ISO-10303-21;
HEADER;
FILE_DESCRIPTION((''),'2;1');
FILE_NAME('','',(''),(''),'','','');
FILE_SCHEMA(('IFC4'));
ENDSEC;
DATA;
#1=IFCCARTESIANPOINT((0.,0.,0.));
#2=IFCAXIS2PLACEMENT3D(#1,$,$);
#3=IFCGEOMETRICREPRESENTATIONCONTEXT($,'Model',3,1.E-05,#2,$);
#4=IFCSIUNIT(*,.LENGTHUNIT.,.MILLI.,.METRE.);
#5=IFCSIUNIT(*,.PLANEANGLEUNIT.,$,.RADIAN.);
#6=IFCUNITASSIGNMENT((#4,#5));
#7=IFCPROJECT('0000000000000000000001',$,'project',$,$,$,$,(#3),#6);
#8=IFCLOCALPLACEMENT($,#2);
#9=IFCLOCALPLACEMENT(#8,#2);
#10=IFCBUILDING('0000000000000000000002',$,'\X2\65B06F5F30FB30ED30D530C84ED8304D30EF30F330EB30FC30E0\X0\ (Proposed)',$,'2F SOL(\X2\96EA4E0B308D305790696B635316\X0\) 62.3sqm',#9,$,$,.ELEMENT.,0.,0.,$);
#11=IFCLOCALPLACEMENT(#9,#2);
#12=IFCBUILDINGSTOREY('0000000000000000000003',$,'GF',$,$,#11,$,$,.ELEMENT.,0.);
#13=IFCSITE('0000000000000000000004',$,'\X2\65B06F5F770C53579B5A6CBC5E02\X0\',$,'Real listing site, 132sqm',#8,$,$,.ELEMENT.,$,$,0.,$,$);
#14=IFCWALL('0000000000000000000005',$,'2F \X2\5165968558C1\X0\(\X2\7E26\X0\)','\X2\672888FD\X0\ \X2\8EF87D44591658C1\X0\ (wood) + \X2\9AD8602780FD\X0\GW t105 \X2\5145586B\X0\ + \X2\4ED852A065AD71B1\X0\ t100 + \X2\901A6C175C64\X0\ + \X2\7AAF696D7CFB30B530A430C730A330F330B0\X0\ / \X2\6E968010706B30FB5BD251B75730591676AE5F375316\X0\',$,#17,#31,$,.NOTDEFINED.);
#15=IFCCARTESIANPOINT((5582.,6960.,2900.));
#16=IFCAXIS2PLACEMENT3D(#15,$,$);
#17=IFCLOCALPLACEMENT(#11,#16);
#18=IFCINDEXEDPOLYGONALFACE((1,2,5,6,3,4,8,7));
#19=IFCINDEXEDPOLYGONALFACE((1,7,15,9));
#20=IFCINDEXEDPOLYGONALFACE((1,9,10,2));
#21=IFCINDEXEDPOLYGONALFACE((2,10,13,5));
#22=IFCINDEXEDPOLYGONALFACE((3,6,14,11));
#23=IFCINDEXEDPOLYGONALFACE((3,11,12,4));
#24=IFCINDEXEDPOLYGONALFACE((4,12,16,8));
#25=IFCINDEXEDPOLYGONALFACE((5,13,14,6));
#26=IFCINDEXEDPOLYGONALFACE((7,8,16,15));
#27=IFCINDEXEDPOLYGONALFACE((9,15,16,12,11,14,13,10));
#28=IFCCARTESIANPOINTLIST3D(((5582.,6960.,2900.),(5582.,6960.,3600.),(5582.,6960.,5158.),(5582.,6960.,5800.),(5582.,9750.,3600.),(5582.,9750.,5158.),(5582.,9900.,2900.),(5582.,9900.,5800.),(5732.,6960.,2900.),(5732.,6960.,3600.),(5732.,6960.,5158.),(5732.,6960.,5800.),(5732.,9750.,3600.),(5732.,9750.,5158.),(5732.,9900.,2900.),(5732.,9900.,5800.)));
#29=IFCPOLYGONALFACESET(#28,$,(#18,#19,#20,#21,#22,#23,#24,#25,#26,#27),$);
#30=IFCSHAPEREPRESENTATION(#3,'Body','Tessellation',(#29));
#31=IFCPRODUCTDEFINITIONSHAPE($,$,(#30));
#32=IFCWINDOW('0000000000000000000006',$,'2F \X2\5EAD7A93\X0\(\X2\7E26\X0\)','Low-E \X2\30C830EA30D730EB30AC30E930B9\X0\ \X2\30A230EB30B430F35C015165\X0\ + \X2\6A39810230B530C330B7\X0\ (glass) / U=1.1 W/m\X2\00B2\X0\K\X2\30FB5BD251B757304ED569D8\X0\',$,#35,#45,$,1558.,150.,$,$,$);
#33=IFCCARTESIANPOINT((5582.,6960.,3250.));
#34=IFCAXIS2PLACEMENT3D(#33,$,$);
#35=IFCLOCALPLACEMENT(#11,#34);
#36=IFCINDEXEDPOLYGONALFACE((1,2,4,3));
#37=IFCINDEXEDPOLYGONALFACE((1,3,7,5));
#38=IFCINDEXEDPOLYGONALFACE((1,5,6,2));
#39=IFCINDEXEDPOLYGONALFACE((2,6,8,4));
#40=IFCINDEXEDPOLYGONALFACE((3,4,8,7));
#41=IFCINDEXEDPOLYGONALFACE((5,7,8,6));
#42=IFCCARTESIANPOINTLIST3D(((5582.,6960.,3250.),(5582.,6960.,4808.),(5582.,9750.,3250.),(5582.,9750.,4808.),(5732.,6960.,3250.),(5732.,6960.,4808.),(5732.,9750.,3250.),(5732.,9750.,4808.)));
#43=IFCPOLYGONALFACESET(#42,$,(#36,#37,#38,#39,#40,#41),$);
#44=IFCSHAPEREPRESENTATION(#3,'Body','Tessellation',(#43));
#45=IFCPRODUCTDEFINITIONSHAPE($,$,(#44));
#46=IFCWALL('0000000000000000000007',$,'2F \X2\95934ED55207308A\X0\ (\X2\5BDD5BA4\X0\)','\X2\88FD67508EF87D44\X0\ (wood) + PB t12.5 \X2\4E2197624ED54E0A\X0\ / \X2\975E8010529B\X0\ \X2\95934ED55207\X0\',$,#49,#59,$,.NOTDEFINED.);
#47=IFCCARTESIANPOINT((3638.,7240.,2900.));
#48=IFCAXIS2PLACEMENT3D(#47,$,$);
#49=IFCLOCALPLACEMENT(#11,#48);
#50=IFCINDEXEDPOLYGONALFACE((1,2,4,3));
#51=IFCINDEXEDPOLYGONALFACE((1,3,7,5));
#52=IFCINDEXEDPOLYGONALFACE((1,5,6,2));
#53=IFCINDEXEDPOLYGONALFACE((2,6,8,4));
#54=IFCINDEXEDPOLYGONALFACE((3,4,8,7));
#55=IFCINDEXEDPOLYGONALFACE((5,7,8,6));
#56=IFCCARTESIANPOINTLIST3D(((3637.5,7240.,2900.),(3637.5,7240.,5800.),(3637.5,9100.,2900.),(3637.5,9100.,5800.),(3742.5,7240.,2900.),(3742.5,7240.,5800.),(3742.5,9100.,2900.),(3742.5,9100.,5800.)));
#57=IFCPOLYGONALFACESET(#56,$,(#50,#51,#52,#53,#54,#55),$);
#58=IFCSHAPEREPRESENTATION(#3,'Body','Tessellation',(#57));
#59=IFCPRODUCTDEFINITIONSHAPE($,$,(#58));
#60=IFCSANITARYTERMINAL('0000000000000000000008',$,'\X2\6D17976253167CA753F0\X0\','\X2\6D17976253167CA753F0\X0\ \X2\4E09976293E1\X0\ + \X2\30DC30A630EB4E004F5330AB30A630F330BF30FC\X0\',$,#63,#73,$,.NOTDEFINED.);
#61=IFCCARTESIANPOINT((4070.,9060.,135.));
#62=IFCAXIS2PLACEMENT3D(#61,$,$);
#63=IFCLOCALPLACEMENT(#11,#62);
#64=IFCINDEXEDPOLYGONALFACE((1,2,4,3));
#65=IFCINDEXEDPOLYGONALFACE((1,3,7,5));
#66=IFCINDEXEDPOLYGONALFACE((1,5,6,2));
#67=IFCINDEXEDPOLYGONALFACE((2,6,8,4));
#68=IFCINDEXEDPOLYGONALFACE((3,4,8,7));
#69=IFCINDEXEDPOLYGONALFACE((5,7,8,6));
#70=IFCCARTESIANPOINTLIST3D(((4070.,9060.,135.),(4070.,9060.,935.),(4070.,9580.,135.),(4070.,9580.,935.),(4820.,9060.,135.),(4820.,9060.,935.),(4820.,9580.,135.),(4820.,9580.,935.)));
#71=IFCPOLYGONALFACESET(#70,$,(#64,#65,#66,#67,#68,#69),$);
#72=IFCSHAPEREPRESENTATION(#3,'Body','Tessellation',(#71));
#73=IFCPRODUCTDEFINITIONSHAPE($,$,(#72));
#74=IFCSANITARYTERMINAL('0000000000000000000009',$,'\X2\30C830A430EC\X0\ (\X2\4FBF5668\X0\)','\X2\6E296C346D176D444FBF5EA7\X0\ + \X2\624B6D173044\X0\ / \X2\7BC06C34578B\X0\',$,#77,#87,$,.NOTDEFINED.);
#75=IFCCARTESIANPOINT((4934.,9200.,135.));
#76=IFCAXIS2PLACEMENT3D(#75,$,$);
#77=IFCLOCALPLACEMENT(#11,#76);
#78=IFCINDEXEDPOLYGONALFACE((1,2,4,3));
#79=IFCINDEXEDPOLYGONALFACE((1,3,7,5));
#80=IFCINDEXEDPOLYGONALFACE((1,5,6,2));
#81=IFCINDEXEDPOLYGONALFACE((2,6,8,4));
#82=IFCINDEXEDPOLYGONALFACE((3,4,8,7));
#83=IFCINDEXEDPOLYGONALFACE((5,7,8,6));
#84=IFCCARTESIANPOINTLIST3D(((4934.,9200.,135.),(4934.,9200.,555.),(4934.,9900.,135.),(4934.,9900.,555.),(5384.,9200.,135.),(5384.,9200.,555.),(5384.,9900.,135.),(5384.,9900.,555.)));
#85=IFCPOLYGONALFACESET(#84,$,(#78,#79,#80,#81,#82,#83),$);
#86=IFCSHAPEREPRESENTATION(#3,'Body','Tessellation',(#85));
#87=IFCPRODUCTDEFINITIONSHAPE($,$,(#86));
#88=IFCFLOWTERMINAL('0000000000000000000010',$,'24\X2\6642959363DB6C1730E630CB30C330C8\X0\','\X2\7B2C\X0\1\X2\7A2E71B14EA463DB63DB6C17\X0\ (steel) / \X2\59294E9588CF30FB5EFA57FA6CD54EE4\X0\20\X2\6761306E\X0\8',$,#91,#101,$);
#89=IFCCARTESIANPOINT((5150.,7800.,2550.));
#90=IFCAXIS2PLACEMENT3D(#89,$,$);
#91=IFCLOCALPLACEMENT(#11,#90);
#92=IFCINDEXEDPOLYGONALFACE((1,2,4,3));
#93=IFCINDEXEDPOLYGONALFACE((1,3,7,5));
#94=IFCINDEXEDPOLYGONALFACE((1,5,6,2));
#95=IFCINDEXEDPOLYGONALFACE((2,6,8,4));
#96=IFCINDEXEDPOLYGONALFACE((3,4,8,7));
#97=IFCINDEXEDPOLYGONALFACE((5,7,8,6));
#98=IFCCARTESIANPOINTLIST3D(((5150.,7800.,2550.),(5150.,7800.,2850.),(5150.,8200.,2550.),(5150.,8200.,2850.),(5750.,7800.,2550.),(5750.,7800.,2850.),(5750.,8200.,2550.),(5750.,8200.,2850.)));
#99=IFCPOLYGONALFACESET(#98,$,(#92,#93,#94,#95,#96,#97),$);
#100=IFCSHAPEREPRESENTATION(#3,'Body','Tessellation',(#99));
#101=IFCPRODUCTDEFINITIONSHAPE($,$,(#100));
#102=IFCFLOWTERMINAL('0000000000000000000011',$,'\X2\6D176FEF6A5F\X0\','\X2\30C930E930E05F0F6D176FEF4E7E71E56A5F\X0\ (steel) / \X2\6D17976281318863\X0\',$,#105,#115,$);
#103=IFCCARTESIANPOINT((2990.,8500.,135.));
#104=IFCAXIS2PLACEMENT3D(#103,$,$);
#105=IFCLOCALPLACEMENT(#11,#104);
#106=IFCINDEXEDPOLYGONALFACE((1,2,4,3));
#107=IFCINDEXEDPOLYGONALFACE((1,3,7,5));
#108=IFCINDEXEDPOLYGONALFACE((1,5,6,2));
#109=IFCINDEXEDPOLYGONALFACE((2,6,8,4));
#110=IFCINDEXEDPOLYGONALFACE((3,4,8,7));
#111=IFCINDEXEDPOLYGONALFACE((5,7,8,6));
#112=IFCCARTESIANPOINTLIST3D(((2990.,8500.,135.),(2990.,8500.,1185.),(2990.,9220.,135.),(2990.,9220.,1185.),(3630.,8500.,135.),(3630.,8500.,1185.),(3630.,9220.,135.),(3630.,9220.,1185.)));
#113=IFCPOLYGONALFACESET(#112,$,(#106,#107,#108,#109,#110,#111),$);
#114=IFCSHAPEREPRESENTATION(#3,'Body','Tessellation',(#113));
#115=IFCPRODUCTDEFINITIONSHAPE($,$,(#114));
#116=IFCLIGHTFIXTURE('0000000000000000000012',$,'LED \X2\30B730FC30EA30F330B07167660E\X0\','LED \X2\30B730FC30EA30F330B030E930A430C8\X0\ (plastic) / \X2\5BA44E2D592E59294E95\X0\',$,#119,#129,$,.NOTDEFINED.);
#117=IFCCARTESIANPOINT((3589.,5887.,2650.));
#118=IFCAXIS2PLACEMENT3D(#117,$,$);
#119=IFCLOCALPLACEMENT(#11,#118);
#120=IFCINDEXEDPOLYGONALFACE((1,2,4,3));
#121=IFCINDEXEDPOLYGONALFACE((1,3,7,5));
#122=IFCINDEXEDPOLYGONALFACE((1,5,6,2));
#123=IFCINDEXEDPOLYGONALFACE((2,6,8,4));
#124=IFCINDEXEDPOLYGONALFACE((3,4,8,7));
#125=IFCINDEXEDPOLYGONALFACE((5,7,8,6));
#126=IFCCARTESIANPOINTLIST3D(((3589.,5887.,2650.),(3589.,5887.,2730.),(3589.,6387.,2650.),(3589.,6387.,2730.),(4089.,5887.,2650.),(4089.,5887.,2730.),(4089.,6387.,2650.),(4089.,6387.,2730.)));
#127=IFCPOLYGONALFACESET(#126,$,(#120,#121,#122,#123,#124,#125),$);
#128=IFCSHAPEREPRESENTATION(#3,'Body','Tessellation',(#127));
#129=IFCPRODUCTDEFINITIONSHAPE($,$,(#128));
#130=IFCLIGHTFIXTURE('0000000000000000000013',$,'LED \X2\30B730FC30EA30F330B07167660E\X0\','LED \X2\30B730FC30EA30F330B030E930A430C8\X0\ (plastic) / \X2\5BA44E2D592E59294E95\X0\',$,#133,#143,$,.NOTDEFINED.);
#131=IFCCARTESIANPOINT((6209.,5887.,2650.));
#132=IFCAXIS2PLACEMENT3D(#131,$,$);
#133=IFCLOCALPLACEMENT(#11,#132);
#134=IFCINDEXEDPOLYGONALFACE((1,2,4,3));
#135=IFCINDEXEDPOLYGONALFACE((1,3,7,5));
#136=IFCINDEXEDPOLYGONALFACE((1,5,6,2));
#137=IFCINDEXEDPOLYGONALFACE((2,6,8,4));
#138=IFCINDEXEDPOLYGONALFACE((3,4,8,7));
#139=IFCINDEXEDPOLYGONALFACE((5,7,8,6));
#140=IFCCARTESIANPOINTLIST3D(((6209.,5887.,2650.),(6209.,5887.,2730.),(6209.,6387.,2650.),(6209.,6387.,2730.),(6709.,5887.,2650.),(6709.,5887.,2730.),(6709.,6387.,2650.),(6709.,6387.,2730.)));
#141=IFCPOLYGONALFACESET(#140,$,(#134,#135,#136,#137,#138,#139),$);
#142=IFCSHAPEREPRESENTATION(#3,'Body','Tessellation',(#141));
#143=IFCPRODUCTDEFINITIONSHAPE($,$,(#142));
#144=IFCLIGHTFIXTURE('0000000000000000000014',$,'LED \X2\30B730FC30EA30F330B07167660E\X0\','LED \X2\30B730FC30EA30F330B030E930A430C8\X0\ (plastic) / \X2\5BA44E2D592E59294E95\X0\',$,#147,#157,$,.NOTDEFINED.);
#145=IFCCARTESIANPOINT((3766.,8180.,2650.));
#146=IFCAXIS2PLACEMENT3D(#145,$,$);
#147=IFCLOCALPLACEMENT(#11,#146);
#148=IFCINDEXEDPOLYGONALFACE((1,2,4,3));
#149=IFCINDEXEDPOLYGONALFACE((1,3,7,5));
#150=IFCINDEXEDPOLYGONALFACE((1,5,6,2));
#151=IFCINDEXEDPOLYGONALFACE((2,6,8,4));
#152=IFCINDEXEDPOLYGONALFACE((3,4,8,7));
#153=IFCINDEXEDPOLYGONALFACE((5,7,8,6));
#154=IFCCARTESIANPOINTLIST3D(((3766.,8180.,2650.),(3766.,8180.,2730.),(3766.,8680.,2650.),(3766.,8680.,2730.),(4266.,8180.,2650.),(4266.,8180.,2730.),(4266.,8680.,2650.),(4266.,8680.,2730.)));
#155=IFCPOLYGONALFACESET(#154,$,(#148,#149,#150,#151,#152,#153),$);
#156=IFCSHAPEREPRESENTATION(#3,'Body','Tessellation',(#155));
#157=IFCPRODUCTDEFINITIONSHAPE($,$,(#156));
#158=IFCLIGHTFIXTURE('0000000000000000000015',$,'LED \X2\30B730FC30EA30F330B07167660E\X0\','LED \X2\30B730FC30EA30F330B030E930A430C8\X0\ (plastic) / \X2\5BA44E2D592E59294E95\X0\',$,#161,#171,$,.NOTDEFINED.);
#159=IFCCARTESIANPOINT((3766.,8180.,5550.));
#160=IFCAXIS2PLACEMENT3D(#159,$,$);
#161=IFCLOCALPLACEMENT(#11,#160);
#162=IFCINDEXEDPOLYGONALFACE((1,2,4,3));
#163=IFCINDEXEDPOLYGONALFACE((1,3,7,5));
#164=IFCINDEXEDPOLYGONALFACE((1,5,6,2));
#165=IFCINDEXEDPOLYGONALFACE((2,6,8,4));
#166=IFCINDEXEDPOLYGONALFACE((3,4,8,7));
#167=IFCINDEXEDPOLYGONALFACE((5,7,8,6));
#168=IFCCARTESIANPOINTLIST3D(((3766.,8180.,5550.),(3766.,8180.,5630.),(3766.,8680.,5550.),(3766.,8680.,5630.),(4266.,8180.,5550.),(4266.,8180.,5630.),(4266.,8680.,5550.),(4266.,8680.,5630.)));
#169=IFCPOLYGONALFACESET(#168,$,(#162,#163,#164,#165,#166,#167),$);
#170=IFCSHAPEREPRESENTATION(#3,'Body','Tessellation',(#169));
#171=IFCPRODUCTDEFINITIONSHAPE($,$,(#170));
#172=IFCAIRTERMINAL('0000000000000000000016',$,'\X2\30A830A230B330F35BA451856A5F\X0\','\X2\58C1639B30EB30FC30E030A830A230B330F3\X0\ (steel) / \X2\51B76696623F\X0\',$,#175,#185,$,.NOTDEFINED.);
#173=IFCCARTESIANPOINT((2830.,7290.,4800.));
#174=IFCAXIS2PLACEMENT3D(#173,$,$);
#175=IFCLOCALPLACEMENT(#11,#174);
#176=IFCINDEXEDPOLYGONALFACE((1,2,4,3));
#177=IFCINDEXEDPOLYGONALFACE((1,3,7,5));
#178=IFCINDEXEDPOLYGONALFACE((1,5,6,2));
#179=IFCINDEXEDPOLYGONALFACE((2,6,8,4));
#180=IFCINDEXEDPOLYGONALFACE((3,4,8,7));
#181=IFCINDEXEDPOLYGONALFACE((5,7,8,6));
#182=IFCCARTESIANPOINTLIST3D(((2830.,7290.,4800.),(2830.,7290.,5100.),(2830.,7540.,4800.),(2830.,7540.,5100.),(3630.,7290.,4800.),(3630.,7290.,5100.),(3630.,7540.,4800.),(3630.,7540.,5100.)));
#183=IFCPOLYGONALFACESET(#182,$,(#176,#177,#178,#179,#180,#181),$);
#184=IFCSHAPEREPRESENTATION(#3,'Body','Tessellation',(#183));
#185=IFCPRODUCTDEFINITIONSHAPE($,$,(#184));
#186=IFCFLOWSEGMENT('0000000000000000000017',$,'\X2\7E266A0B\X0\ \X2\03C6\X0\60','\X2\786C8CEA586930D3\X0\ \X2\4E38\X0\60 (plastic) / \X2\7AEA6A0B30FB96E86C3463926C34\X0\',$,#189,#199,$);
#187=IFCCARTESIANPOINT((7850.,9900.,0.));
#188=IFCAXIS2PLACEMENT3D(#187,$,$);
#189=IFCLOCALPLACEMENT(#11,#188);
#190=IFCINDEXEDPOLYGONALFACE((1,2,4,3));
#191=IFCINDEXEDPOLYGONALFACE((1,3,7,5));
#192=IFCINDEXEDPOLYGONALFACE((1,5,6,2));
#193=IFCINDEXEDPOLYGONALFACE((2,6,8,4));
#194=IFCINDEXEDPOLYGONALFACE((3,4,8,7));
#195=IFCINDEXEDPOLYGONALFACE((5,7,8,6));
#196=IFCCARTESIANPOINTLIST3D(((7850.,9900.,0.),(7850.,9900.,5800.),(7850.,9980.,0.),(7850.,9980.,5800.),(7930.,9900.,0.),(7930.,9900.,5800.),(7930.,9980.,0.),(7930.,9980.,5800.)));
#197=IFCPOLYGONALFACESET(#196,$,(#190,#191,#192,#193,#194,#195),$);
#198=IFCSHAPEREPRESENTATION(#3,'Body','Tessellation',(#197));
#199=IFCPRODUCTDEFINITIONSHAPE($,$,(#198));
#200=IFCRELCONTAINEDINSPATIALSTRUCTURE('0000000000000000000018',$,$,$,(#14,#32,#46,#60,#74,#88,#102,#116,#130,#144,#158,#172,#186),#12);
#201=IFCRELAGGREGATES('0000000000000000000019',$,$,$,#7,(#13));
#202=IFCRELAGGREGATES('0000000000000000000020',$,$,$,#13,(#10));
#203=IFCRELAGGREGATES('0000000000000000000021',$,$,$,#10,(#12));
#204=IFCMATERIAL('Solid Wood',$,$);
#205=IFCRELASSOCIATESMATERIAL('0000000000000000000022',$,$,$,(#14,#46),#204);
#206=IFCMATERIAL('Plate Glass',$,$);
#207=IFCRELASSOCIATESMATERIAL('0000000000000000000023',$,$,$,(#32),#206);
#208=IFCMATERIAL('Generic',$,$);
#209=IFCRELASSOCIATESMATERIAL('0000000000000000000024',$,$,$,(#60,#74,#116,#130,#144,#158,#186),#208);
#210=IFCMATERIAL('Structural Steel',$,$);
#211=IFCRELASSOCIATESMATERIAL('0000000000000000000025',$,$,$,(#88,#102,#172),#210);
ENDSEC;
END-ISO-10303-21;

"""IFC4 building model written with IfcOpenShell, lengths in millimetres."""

from ifc_helpers import new_model, si_unit, frame, frame_2d, origin, place, context, project, spatial, rectangle, extrude, material, element, fill, save


model = new_model("IFC4")

# Units and contexts
model_context = context("Model", 3, precision=1e-05, world=origin())
ifc_project = project(units=[si_unit("LENGTHUNIT", "METRE", prefix="MILLI"), si_unit("PLANEANGLEUNIT", "RADIAN")], contexts=[model_context])

# Site, building, storey
site_placement = place(None, origin())
site = spatial("IfcSite", under=ifc_project, at=site_placement, Name="新潟県南魚沼市", ObjectType="Real listing site, 132sqm", CompositionType="ELEMENT", RefElevation=0.0)
building_placement = place(site_placement, origin())
building = spatial("IfcBuilding", under=site, at=building_placement, Name="新潟・ロフト付きワンルーム (Proposed)", ObjectType="2F SOL(雪下ろし適正化) 62.3sqm", CompositionType="ELEMENT", ElevationOfRefHeight=0.0, ElevationOfTerrain=0.0)
storey_placement = place(building_placement, origin())
storey = spatial("IfcBuildingStorey", under=building, at=storey_placement, Name="GF", CompositionType="ELEMENT", Elevation=0.0)

# Shared definitions
ifc_material_1 = material(Name="Solid Wood")

# Shared definitions
ifc_material_2 = material(Name="Plate Glass")

# Wall, opening, window
wall_1_placement = place(storey_placement, frame((5582.0, 6960.0, 2900.0)))
wall_1 = element("IfcWall", 1, at=wall_1_placement, inside=storey, material=ifc_material_1, Name="2F 入隅壁(縦)", Description="木製 軸組外壁 (wood) + 高性能GW t105 充填 + 付加断熱 t100 + 通気層 + 窯業系サイディング / 準耐火・寒冷地外皮強化", PredefinedType="NOTDEFINED", context=model_context, shape_type="SweptSolid", body=[
    extrude(rectangle(XDim=150.0, YDim=2940.0, at=frame_2d((75.0, 1470.0))), frame((5582.0, 6960.0, 2900.0)), (0.0, 0.0, 1.0), 2900.0),
])
opening_1_placement = place(storey_placement, frame((5582.0, 6960.0, 3250.0)))
opening_1 = element("IfcOpeningElement", 2, at=opening_1_placement, cuts=wall_1, PredefinedType="NOTDEFINED", context=model_context, shape_type="SweptSolid", body=[
    extrude(rectangle(XDim=150.0, YDim=2790.0, at=frame_2d((75.0, 1395.0))), frame((5582.0, 6960.0, 3250.0)), (0.0, 0.0, 1.0), 1558.0),
])
window_1_placement = place(storey_placement, frame((5582.0, 6960.0, 3250.0)))
window_1 = element("IfcWindow", 3, at=window_1_placement, inside=storey, material=ifc_material_2, Name="2F 庭窓(縦)", Description="Low-E トリプルガラス アルゴン封入 + 樹脂サッシ (glass) / U=1.1 W/m²K・寒冷地仕様", OverallHeight=1558.0, OverallWidth=150.0, context=model_context, shape_type="SweptSolid", body=[
    extrude(rectangle(XDim=150.0, YDim=2790.0, at=frame_2d((75.0, 1395.0))), frame((5582.0, 6960.0, 3250.0)), (0.0, 0.0, 1.0), 1558.0),
])
fill(opening_1, window_1)

# Wall
wall_2_placement = place(storey_placement, frame((3638.0, 7240.0, 2900.0)))
element("IfcWall", 4, at=wall_2_placement, inside=storey, material=ifc_material_1, Name="2F 間仕切り (寝室)", Description="製材軸組 (wood) + PB t12.5 両面仕上 / 非耐力 間仕切", PredefinedType="NOTDEFINED", context=model_context, shape_type="SweptSolid", body=[
    extrude(rectangle(XDim=105.0, YDim=1860.0, at=frame_2d((52.0, 930.0))), frame((3638.0, 7240.0, 2900.0)), (0.0, 0.0, 1.0), 2900.0),
])

# Sanitary terminals
ifc_material_3 = material(Name="Generic")
sanitary_terminal_1_placement = place(storey_placement, frame((4070.0, 9060.0, 135.0)))
element("IfcSanitaryTerminal", 5, at=sanitary_terminal_1_placement, inside=storey, material=ifc_material_3, Name="洗面化粧台", Description="洗面化粧台 三面鏡 + ボウル一体カウンター", PredefinedType="NOTDEFINED", context=model_context, shape_type="SweptSolid", body=[
    extrude(rectangle(XDim=750.0, YDim=520.0, at=frame_2d((375.0, 260.0))), frame((4070.0, 9060.0, 135.0)), (0.0, 0.0, 1.0), 800.0),
])
sanitary_terminal_2_placement = place(storey_placement, frame((4934.0, 9200.0, 135.0)))
element("IfcSanitaryTerminal", 6, at=sanitary_terminal_2_placement, inside=storey, material=ifc_material_3, Name="トイレ (便器)", Description="温水洗浄便座 + 手洗い / 節水型", PredefinedType="NOTDEFINED", context=model_context, shape_type="SweptSolid", body=[
    extrude(rectangle(XDim=450.0, YDim=700.0, at=frame_2d((225.0, 350.0))), frame((4934.0, 9200.0, 135.0)), (0.0, 0.0, 1.0), 420.0),
])

# Flow terminals
ifc_material_4 = material(Name="Structural Steel")
flow_terminal_1_placement = place(storey_placement, frame((5150.0, 7800.0, 2550.0)))
element("IfcFlowTerminal", 7, at=flow_terminal_1_placement, inside=storey, material=ifc_material_4, Name="24時間換気ユニット", Description="第1種熱交換換気 (steel) / 天井裏・建基法令20条の8", context=model_context, shape_type="SweptSolid", body=[
    extrude(rectangle(XDim=600.0, YDim=400.0, at=frame_2d((300.0, 200.0))), frame((5150.0, 7800.0, 2550.0)), (0.0, 0.0, 1.0), 300.0),
])
flow_terminal_2_placement = place(storey_placement, frame((2990.0, 8500.0, 135.0)))
element("IfcFlowTerminal", 8, at=flow_terminal_2_placement, inside=storey, material=ifc_material_4, Name="洗濯機", Description="ドラム式洗濯乾燥機 (steel) / 洗面脱衣", context=model_context, shape_type="SweptSolid", body=[
    extrude(rectangle(XDim=640.0, YDim=720.0, at=frame_2d((320.0, 360.0))), frame((2990.0, 8500.0, 135.0)), (0.0, 0.0, 1.0), 1050.0),
])

# Light fixtures
light_fixture_1_placement = place(storey_placement, frame((3589.0, 5887.0, 2650.0)))
element("IfcLightFixture", 9, at=light_fixture_1_placement, inside=storey, material=ifc_material_3, Name="LED シーリング照明", Description="LED シーリングライト (plastic) / 室中央天井", PredefinedType="NOTDEFINED", context=model_context, shape_type="SweptSolid", body=[
    extrude(rectangle(XDim=500.0, YDim=500.0, at=frame_2d((250.0, 250.0))), frame((3589.0, 5887.0, 2650.0)), (0.0, 0.0, 1.0), 80.0),
])
light_fixture_2_placement = place(storey_placement, frame((6209.0, 5887.0, 2650.0)))
element("IfcLightFixture", 10, at=light_fixture_2_placement, inside=storey, material=ifc_material_3, Name="LED シーリング照明", Description="LED シーリングライト (plastic) / 室中央天井", PredefinedType="NOTDEFINED", context=model_context, shape_type="SweptSolid", body=[
    extrude(rectangle(XDim=500.0, YDim=500.0, at=frame_2d((250.0, 250.0))), frame((6209.0, 5887.0, 2650.0)), (0.0, 0.0, 1.0), 80.0),
])
light_fixture_3_placement = place(storey_placement, frame((3766.0, 8180.0, 2650.0)))
element("IfcLightFixture", 11, at=light_fixture_3_placement, inside=storey, material=ifc_material_3, Name="LED シーリング照明", Description="LED シーリングライト (plastic) / 室中央天井", PredefinedType="NOTDEFINED", context=model_context, shape_type="SweptSolid", body=[
    extrude(rectangle(XDim=500.0, YDim=500.0, at=frame_2d((250.0, 250.0))), frame((3766.0, 8180.0, 2650.0)), (0.0, 0.0, 1.0), 80.0),
])
light_fixture_4_placement = place(storey_placement, frame((3766.0, 8180.0, 5550.0)))
element("IfcLightFixture", 12, at=light_fixture_4_placement, inside=storey, material=ifc_material_3, Name="LED シーリング照明", Description="LED シーリングライト (plastic) / 室中央天井", PredefinedType="NOTDEFINED", context=model_context, shape_type="SweptSolid", body=[
    extrude(rectangle(XDim=500.0, YDim=500.0, at=frame_2d((250.0, 250.0))), frame((3766.0, 8180.0, 5550.0)), (0.0, 0.0, 1.0), 80.0),
])

# Air terminal
air_terminal_placement = place(storey_placement, frame((2830.0, 7290.0, 4800.0)))
element("IfcAirTerminal", 13, at=air_terminal_placement, inside=storey, material=ifc_material_4, Name="エアコン室内機", Description="壁掛ルームエアコン (steel) / 冷暖房", PredefinedType="NOTDEFINED", context=model_context, shape_type="SweptSolid", body=[
    extrude(rectangle(XDim=800.0, YDim=250.0, at=frame_2d((400.0, 125.0))), frame((2830.0, 7290.0, 4800.0)), (0.0, 0.0, 1.0), 300.0),
])

# Flow segment
flow_segment_placement = place(storey_placement, frame((7850.0, 9900.0, 0.0)))
element("IfcFlowSegment", 14, at=flow_segment_placement, inside=storey, material=ifc_material_3, Name="縦樋 φ60", Description="硬質塩ビ 丸60 (plastic) / 竪樋・雨水排水", context=model_context, shape_type="SweptSolid", body=[
    extrude(rectangle(XDim=80.0, YDim=80.0, at=frame_2d((40.0, 40.0))), frame((7850.0, 9900.0, 0.0)), (0.0, 0.0, 1.0), 5800.0),
])

save(model, "model.ifc")
